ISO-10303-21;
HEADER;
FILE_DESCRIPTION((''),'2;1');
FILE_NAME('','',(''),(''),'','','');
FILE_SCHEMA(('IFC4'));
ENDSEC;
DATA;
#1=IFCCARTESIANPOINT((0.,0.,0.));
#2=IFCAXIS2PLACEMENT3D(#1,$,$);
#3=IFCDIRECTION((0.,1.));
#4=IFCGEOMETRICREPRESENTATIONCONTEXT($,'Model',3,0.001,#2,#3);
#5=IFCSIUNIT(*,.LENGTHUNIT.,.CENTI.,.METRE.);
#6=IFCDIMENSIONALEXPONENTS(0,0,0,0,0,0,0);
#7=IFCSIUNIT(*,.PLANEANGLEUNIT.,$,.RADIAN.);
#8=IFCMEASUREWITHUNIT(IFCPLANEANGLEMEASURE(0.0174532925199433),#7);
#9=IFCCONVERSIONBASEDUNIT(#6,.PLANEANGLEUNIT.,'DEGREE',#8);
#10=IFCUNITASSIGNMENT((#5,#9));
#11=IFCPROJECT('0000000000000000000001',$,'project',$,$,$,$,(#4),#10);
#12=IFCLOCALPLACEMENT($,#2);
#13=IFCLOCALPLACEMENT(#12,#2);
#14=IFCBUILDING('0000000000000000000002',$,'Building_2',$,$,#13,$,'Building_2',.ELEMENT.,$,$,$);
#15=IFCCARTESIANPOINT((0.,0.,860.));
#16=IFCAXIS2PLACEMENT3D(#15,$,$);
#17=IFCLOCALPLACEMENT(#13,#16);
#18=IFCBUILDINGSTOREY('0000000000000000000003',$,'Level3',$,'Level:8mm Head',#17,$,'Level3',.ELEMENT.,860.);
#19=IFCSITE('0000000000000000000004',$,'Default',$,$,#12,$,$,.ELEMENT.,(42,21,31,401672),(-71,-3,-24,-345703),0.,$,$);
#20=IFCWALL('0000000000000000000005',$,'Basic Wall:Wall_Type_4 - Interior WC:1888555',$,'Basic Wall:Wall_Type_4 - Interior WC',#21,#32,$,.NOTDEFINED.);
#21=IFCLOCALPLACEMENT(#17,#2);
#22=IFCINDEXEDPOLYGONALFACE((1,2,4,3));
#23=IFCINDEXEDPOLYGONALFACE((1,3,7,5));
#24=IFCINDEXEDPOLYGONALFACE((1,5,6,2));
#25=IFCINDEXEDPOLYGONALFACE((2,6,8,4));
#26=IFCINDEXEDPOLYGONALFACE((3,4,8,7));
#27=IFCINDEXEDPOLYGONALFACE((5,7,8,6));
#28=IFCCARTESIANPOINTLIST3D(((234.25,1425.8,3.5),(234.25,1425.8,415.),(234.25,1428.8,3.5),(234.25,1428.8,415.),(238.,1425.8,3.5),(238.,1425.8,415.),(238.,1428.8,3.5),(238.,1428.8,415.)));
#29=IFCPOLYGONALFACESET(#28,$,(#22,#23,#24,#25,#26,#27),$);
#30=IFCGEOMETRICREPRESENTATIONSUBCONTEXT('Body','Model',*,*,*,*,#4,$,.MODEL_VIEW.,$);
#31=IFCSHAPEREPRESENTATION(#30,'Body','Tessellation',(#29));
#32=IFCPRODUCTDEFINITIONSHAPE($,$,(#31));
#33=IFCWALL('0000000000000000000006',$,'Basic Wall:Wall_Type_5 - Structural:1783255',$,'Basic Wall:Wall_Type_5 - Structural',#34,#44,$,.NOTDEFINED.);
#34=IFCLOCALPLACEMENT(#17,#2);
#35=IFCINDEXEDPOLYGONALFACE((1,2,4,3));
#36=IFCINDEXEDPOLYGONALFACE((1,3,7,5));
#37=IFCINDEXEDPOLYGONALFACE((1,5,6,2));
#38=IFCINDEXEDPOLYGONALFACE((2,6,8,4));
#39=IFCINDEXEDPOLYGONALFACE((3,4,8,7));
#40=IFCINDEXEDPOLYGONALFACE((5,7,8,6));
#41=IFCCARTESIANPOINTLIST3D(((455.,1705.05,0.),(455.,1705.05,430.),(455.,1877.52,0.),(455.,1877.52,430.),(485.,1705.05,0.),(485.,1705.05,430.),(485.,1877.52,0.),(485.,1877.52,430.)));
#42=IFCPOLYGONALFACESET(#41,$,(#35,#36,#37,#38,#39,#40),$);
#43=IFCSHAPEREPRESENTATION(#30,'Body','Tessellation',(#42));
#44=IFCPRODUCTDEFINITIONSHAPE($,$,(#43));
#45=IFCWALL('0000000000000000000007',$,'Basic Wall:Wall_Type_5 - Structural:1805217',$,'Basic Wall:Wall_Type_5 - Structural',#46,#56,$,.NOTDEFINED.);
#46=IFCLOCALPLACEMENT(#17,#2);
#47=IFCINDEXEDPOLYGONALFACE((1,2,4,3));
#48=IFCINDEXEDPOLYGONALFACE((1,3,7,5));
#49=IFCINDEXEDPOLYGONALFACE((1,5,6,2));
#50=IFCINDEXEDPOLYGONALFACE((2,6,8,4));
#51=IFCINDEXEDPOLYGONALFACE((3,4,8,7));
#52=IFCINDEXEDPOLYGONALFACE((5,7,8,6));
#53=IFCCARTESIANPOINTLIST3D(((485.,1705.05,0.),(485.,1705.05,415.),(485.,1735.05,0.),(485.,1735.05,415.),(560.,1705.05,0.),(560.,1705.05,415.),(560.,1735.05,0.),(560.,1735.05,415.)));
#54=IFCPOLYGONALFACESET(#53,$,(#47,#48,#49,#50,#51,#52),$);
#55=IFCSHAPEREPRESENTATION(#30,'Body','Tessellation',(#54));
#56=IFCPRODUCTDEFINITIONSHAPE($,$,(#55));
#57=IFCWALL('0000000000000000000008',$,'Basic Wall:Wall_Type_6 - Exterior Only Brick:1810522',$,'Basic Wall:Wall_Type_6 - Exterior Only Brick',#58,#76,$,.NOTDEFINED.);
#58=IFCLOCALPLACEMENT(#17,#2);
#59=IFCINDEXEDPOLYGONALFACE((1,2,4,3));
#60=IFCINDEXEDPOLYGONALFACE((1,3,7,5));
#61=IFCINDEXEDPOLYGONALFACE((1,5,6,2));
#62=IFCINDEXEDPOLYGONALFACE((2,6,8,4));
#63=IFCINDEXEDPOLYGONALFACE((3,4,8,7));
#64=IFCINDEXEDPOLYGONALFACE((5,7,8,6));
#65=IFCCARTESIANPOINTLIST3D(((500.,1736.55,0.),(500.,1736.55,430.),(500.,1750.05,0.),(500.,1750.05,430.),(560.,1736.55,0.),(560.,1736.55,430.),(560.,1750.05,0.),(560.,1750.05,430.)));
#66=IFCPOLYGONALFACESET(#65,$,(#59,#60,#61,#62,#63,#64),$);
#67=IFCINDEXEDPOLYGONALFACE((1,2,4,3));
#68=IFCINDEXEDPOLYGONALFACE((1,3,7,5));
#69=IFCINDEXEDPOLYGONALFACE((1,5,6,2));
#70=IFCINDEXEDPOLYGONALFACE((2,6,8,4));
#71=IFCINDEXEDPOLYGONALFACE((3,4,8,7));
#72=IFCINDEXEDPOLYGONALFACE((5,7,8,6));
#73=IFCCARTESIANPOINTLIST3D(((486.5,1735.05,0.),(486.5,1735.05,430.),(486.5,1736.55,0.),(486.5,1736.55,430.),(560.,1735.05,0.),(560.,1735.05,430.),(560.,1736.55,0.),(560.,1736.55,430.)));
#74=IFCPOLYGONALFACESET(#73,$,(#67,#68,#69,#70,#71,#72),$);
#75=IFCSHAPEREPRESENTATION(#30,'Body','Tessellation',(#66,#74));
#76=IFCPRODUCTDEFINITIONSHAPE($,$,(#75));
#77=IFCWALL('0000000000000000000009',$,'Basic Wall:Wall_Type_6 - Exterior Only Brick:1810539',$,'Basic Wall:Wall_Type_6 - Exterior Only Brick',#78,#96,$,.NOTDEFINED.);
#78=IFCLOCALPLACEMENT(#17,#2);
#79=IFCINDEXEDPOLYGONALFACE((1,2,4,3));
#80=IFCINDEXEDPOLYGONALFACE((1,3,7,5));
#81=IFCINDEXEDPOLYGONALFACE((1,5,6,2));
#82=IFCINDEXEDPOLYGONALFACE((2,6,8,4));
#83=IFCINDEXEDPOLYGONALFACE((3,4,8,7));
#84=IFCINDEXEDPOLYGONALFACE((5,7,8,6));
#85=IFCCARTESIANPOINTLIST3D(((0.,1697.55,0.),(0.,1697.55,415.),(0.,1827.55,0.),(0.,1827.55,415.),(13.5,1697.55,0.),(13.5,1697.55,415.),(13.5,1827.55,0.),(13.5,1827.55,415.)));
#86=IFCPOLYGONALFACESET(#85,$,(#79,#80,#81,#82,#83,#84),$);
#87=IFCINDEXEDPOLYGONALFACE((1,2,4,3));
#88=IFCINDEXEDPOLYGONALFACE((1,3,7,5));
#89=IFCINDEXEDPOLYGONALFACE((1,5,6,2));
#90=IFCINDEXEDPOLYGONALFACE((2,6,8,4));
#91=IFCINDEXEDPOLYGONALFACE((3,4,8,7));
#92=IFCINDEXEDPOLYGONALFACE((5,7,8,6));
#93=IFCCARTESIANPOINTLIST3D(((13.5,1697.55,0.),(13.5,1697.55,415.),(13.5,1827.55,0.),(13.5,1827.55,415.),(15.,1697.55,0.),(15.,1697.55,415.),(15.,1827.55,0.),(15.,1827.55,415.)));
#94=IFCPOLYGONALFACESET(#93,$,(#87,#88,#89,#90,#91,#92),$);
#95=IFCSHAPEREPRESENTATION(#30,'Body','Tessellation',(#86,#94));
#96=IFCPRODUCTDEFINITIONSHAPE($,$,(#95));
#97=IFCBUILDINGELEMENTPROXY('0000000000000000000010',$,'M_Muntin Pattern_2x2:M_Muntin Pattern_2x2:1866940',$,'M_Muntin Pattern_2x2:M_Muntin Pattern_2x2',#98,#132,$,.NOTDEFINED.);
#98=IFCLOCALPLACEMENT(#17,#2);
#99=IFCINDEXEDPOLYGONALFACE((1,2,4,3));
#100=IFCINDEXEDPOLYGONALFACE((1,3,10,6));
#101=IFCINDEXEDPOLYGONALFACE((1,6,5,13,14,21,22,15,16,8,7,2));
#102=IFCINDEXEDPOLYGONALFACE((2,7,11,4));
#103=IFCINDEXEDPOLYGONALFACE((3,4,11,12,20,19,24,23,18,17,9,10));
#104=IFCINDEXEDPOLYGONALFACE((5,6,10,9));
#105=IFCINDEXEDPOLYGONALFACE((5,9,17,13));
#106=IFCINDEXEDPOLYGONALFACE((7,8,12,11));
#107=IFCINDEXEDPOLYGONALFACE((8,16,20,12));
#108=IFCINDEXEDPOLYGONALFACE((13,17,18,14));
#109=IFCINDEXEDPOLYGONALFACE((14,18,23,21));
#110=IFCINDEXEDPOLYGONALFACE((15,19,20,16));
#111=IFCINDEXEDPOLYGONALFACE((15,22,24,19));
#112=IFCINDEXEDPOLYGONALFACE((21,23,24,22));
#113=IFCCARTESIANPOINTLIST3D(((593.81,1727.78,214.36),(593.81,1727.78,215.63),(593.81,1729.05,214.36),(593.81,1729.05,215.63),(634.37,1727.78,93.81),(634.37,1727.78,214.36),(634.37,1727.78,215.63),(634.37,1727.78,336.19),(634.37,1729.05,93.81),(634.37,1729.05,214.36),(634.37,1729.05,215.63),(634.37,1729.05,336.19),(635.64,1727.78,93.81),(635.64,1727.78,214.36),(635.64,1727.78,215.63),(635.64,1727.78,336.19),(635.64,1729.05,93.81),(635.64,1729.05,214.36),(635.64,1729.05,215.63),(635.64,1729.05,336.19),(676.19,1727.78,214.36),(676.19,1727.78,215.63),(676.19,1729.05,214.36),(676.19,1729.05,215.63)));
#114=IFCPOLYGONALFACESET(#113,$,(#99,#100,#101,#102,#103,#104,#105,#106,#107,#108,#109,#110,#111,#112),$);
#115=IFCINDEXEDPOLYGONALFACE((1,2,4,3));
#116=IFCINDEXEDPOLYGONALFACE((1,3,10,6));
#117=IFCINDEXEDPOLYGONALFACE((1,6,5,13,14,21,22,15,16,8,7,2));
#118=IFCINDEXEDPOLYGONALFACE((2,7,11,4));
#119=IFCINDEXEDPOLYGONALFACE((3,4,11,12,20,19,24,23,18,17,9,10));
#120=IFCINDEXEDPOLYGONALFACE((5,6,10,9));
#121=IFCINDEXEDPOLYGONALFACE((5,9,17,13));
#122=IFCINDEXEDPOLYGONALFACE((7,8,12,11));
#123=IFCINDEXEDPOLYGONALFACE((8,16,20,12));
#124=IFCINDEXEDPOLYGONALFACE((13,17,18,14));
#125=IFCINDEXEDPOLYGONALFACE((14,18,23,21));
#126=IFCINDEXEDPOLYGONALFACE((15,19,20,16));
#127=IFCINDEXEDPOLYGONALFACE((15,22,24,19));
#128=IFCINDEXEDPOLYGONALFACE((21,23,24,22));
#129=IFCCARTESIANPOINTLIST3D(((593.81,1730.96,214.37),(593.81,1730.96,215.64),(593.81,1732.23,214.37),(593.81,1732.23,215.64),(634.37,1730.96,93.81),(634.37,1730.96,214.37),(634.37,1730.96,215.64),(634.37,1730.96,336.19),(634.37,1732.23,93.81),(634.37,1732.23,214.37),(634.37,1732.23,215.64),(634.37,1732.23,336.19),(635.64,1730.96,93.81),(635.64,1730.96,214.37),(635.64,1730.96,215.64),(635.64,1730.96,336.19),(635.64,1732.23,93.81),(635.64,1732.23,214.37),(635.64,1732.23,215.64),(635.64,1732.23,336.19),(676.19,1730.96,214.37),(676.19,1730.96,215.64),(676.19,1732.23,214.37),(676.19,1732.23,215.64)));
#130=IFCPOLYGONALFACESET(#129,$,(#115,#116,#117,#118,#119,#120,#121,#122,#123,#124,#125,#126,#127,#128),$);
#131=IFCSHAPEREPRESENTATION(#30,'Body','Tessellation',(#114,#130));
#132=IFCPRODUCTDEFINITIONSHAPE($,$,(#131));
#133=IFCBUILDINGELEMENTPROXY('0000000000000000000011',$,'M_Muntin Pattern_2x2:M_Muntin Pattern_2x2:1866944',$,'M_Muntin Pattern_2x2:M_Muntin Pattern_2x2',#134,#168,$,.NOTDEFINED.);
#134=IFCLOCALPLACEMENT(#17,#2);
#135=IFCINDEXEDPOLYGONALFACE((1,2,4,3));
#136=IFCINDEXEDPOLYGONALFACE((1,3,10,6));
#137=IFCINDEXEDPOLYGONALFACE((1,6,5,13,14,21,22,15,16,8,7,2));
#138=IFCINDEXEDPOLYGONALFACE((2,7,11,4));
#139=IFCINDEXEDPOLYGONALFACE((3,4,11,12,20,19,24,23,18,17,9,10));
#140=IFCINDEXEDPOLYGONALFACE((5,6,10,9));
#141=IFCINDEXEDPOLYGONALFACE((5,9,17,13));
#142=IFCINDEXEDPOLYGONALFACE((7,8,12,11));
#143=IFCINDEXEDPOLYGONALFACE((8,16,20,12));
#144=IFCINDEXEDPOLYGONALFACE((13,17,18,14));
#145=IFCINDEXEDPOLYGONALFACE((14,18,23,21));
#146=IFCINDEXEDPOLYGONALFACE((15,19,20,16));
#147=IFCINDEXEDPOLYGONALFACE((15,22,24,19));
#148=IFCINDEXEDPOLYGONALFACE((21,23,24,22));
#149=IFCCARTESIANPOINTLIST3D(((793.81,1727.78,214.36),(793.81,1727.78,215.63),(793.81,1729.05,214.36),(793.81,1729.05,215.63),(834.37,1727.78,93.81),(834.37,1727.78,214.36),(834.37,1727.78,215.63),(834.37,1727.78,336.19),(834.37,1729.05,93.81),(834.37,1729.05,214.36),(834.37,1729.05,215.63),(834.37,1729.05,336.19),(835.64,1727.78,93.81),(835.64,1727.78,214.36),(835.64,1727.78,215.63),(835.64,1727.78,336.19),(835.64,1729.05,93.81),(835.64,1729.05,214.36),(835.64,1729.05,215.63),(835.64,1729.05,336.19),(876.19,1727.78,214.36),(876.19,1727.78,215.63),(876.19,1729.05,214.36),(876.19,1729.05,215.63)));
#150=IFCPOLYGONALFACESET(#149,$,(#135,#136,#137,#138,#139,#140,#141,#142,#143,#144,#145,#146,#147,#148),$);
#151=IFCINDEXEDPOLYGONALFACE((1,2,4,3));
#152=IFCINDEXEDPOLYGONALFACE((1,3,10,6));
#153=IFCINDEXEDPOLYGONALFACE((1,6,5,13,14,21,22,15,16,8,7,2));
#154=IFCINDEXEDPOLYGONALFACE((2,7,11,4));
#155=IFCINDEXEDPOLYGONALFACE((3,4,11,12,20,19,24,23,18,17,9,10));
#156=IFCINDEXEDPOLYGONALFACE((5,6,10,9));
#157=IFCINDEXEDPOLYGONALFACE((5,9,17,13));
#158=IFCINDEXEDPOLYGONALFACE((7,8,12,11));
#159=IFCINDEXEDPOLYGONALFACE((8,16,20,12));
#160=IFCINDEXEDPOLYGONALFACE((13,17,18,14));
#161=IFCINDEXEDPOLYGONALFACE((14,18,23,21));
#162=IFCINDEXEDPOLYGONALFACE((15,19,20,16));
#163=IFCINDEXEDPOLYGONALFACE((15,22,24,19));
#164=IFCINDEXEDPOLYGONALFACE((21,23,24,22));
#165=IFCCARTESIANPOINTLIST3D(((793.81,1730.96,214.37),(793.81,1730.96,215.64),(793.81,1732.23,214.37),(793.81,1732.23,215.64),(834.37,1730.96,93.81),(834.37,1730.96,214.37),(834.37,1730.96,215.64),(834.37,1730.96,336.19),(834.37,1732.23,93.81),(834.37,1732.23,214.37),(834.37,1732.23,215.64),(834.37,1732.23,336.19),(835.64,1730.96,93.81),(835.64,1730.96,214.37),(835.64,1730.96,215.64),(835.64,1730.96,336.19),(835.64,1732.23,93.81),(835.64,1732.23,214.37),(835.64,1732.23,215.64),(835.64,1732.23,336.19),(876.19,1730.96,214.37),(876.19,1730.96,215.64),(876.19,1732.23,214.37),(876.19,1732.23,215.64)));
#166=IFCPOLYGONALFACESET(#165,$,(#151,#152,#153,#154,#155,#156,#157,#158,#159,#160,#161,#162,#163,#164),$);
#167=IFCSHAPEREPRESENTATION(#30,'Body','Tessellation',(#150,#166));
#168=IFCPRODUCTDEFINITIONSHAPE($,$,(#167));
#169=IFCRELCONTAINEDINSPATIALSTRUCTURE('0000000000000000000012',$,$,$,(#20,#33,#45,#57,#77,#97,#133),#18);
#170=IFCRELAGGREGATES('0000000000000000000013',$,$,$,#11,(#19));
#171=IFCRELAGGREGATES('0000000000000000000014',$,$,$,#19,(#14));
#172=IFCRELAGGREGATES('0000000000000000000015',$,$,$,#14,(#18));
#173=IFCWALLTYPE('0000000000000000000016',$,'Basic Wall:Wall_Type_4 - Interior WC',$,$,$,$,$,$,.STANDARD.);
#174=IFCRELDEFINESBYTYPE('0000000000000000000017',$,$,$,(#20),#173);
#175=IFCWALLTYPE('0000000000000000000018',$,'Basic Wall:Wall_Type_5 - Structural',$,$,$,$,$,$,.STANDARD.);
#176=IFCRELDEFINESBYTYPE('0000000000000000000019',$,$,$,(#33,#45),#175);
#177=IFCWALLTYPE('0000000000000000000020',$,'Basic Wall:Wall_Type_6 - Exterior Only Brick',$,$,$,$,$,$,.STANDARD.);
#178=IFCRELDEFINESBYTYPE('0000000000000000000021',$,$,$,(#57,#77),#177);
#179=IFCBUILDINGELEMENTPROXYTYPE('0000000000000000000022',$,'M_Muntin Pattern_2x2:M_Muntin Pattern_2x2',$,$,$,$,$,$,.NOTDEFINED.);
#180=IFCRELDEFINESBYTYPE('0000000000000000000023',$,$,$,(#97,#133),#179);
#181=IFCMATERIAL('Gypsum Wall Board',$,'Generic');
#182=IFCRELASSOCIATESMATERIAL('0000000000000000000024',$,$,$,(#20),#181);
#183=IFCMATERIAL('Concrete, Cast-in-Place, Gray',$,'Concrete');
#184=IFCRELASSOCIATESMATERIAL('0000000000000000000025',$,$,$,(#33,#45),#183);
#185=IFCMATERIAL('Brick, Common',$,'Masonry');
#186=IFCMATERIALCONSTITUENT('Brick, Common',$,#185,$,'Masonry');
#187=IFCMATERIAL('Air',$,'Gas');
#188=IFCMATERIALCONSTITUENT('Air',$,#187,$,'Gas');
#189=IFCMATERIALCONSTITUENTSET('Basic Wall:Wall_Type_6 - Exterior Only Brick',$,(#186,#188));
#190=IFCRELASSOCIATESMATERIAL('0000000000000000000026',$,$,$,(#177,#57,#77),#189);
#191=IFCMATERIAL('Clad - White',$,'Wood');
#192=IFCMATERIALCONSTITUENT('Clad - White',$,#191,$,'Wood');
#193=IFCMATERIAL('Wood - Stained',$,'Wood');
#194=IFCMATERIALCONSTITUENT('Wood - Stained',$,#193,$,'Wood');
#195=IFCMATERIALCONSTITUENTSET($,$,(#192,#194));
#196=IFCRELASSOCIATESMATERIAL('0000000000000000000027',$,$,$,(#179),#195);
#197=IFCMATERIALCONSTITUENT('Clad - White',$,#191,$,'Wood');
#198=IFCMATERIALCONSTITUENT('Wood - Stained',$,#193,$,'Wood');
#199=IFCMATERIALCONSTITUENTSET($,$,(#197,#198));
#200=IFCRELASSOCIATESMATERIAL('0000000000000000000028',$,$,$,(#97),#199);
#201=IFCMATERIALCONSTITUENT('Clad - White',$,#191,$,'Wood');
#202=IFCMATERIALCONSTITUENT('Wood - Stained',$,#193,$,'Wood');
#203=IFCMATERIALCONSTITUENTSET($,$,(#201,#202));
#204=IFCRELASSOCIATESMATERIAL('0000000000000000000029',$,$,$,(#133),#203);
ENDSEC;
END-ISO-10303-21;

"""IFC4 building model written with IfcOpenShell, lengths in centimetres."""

from ifc_helpers import new_model, entity, si_unit, converted_unit, direction, frame, origin, place, context, subcontext, project, spatial, indexed_curve, outline, extrude, source, transform, mapped, material, constituent, constituent_set, type_object, type_shapes, element, save


model = new_model("IFC4")

# Units and contexts
model_context = context("Model", 3, precision=0.001, world=origin(), true_north=direction((0.0, 1.0)))
body_context = subcontext(model_context, "Body", "Model", "MODEL_VIEW")
ifc_project = project(units=[si_unit("LENGTHUNIT", "METRE", prefix="CENTI"), converted_unit("PLANEANGLEUNIT", "DEGREE", entity("IfcPlaneAngleMeasure", 0.0174532925199433), si_unit("PLANEANGLEUNIT", "RADIAN"), dimensions=[0, 0, 0, 0, 0, 0, 0])], contexts=[model_context])

# Site, building, storey
site_placement = place(None, origin())
site = spatial("IfcSite", under=ifc_project, at=site_placement, Name="Default", CompositionType="ELEMENT", RefLatitude=(42, 21, 31, 401672), RefLongitude=(-71, -3, -24, -345703), RefElevation=0.0)
building_placement = place(site_placement, origin())
building = spatial("IfcBuilding", under=site, at=building_placement, Name="Building_2", LongName="Building_2", CompositionType="ELEMENT")
storey_placement = place(building_placement, frame((0.0, 0.0, 860.0)))
storey = spatial("IfcBuildingStorey", under=building, at=storey_placement, Name="Level3", ObjectType="Level:8mm Head", LongName="Level3", CompositionType="ELEMENT", Elevation=860.0)

# Shared definitions
ifc_material_1 = material(Name="Brick, Common", Category="Masonry")
ifc_material_2 = material(Name="Air", Category="Gas")
ifc_material_3 = material(Name="Gypsum Wall Board", Category="Generic")

# Walls
wall_type_1 = type_object("IfcWallType", Name="Basic Wall:Wall_Type_4 - Interior WC", PredefinedType="STANDARD")
wall_1_placement = place(storey_placement, frame((234.25, 1427.3, 3.5)))
element("IfcWall", 1, at=wall_1_placement, inside=storey, type_object=wall_type_1, material=ifc_material_3, Name="Basic Wall:Wall_Type_4 - Interior WC:1888555", ObjectType="Basic Wall:Wall_Type_4 - Interior WC", PredefinedType="NOTDEFINED", context=body_context, shape_type="SweptSolid", body=[
    extrude(outline(indexed_curve([(3.75, 1.5), (0.0, 1.5), (0.0, -1.5), (3.75, -1.5), (3.75, 1.5)], self_intersect=False)), origin(), (0.0, 0.0, 1.0), 411.5),
])
ifc_material_4 = material(Name="Concrete, Cast-in-Place, Gray", Category="Concrete")
wall_type_2 = type_object("IfcWallType", Name="Basic Wall:Wall_Type_5 - Structural", PredefinedType="STANDARD")
wall_2_placement = place(storey_placement, frame((470.0, 1877.53, 0.0), z_axis=(0.0, 0.0, 1.0), x_axis=(0.0, -1.0, 0.0)))
element("IfcWall", 2, at=wall_2_placement, inside=storey, type_object=wall_type_2, material=ifc_material_4, Name="Basic Wall:Wall_Type_5 - Structural:1783255", ObjectType="Basic Wall:Wall_Type_5 - Structural", PredefinedType="NOTDEFINED", context=body_context, shape_type="SweptSolid", body=[
    extrude(outline(indexed_curve([(172.47, 15.0), (0.0, 15.0), (0.0, -15.0), (172.47, -15.0), (172.47, 15.0)], self_intersect=False)), origin(), (0.0, 0.0, 1.0), 430.0),
])
wall_3_placement = place(storey_placement, frame((485.0, 1720.05, 0.0)))
element("IfcWall", 3, at=wall_3_placement, inside=storey, type_object=wall_type_2, material=ifc_material_4, Name="Basic Wall:Wall_Type_5 - Structural:1805217", ObjectType="Basic Wall:Wall_Type_5 - Structural", PredefinedType="NOTDEFINED", context=body_context, shape_type="SweptSolid", body=[
    extrude(outline(indexed_curve([(75.0, 15.0), (0.0, 15.0), (0.0, -15.0), (75.0, -15.0), (75.0, 15.0)], self_intersect=False)), origin(), (0.0, 0.0, 1.0), 415.0),
])
ifc_constituent_1 = constituent(ifc_material_1, Name="Brick, Common", Category="Masonry")
ifc_constituent_2 = constituent(ifc_material_2, Name="Air", Category="Gas")
ifc_constituent_set_1 = constituent_set(constituents=[ifc_constituent_1, ifc_constituent_2], Name="Basic Wall:Wall_Type_6 - Exterior Only Brick")
wall_type_3 = type_object("IfcWallType", Name="Basic Wall:Wall_Type_6 - Exterior Only Brick", PredefinedType="STANDARD", material=ifc_constituent_set_1)
wall_4_placement = place(storey_placement, frame((500.0, 1742.55, 0.0)))
element("IfcWall", 4, at=wall_4_placement, inside=storey, type_object=wall_type_3, material=ifc_constituent_set_1, Name="Basic Wall:Wall_Type_6 - Exterior Only Brick:1810522", ObjectType="Basic Wall:Wall_Type_6 - Exterior Only Brick", PredefinedType="NOTDEFINED", context=body_context, shape_type="SweptSolid", body=[
    extrude(outline(indexed_curve([(-6.75, -30.0), (6.75, -30.0), (6.75, 30.0), (-6.75, 30.0), (-6.75, -30.0)], self_intersect=False)), frame((30.0, 0.75, 0.0), z_axis=(0.0, 0.0, 1.0), x_axis=(0.0, -1.0, 0.0)), (0.0, 0.0, 1.0), 430.0),
    extrude(outline(indexed_curve([(-0.75, -36.75), (0.75, -36.75), (0.75, 36.75), (-0.75, 36.75), (-0.75, -36.75)], self_intersect=False)), frame((23.25, -6.75, 0.0), z_axis=(0.0, 0.0, 1.0), x_axis=(0.0, -1.0, 0.0)), (0.0, 0.0, 1.0), 430.0),
])
wall_5_placement = place(storey_placement, frame((7.5, 1697.55, 0.0), z_axis=(0.0, 0.0, 1.0), x_axis=(0.0, 1.0, 0.0)))
element("IfcWall", 5, at=wall_5_placement, inside=storey, type_object=wall_type_3, material=ifc_constituent_set_1, Name="Basic Wall:Wall_Type_6 - Exterior Only Brick:1810539", ObjectType="Basic Wall:Wall_Type_6 - Exterior Only Brick", PredefinedType="NOTDEFINED", context=body_context, shape_type="SweptSolid", body=[
    extrude(outline(indexed_curve([(-6.75, -65.0), (6.75, -65.0), (6.75, 65.0), (-6.75, 65.0), (-6.75, -65.0)], self_intersect=False)), frame((65.0, 0.75, 0.0), z_axis=(0.0, 0.0, 1.0), x_axis=(0.0, -1.0, 0.0)), (0.0, 0.0, 1.0), 415.0),
    extrude(outline(indexed_curve([(-0.75, -65.0), (0.75, -65.0), (0.75, 65.0), (-0.75, 65.0), (-0.75, -65.0)], self_intersect=False)), frame((65.0, -6.75, 0.0), z_axis=(0.0, 0.0, 1.0), x_axis=(0.0, 1.0, 0.0)), (0.0, 0.0, 1.0), 415.0),
])

# Building element proxies
ifc_material_5 = material(Name="Clad - White", Category="Wood")
ifc_constituent_3 = constituent(ifc_material_5, Name="Clad - White", Category="Wood")
ifc_material_6 = material(Name="Wood - Stained", Category="Wood")
ifc_constituent_4 = constituent(ifc_material_6, Name="Wood - Stained", Category="Wood")
ifc_constituent_set_2 = constituent_set(constituents=[ifc_constituent_3, ifc_constituent_4])
ifc_constituent_5 = constituent(ifc_material_5, Name="Clad - White", Category="Wood")
ifc_constituent_6 = constituent(ifc_material_6, Name="Wood - Stained", Category="Wood")
ifc_constituent_set_3 = constituent_set(constituents=[ifc_constituent_5, ifc_constituent_6])
building_element_proxy_type_1 = type_object("IfcBuildingElementProxyType", Name="M_Muntin Pattern_2x2:M_Muntin Pattern_2x2", PredefinedType="NOTDEFINED", material=ifc_constituent_set_3)
shared_shape_1 = source(origin(), body_context, "Body", "SweptSolid", [
    extrude(outline(indexed_curve([(0.64, -0.64), (121.19, -0.64), (121.19, 0.63), (0.64, 0.63), (0.64, 41.19), (-0.63, 41.19), (-0.63, 0.63), (-121.19, 0.63), (-121.19, -0.64), (-0.63, -0.64), (-0.63, -41.19), (0.64, -41.19), (0.64, -0.64)], self_intersect=False)), frame((0.0, 0.95, 121.19), z_axis=(0.0, 1.0, 0.0), x_axis=(0.0, 0.0, 1.0)), (0.0, 0.0, 1.0), 1.27),
    extrude(outline(indexed_curve([(0.64, -0.64), (121.19, -0.64), (121.19, 0.63), (0.64, 0.63), (0.64, 41.19), (-0.63, 41.19), (-0.63, 0.63), (-121.19, 0.63), (-121.19, -0.64), (-0.63, -0.64), (-0.63, -41.19), (0.64, -41.19), (0.64, -0.64)], self_intersect=False)), frame((0.0, -2.22, 121.19), z_axis=(0.0, 1.0, 0.0), x_axis=(0.0, 0.0, 1.0)), (0.0, 0.0, 1.0), 1.27),
])
type_shapes(building_element_proxy_type_1, [shared_shape_1])
proxy_1_placement = place(storey_placement, frame((635.0, 1730.0, 93.81), z_axis=(0.0, 0.0, 1.0), x_axis=(-1.0, 0.0, 0.0)))
element("IfcBuildingElementProxy", 6, at=proxy_1_placement, inside=storey, type_object=building_element_proxy_type_1, material=ifc_constituent_set_2, Name="M_Muntin Pattern_2x2:M_Muntin Pattern_2x2:1866940", ObjectType="M_Muntin Pattern_2x2:M_Muntin Pattern_2x2", PredefinedType="NOTDEFINED", context=body_context, shape_type="MappedRepresentation", body=[
    mapped(shared_shape_1, transform((0.0, 0.0, 0.0), scale=1.0)),
])
ifc_constituent_7 = constituent(ifc_material_5, Name="Clad - White", Category="Wood")
ifc_constituent_8 = constituent(ifc_material_6, Name="Wood - Stained", Category="Wood")
ifc_constituent_set_4 = constituent_set(constituents=[ifc_constituent_7, ifc_constituent_8])
proxy_2_placement = place(storey_placement, frame((835.0, 1730.0, 93.81), z_axis=(0.0, 0.0, 1.0), x_axis=(-1.0, 0.0, 0.0)))
element("IfcBuildingElementProxy", 7, at=proxy_2_placement, inside=storey, type_object=building_element_proxy_type_1, material=ifc_constituent_set_4, Name="M_Muntin Pattern_2x2:M_Muntin Pattern_2x2:1866944", ObjectType="M_Muntin Pattern_2x2:M_Muntin Pattern_2x2", PredefinedType="NOTDEFINED", context=body_context, shape_type="MappedRepresentation", body=[
    mapped(shared_shape_1, transform((0.0, 0.0, 0.0), scale=1.0)),
])

save(model, "model.ifc")
